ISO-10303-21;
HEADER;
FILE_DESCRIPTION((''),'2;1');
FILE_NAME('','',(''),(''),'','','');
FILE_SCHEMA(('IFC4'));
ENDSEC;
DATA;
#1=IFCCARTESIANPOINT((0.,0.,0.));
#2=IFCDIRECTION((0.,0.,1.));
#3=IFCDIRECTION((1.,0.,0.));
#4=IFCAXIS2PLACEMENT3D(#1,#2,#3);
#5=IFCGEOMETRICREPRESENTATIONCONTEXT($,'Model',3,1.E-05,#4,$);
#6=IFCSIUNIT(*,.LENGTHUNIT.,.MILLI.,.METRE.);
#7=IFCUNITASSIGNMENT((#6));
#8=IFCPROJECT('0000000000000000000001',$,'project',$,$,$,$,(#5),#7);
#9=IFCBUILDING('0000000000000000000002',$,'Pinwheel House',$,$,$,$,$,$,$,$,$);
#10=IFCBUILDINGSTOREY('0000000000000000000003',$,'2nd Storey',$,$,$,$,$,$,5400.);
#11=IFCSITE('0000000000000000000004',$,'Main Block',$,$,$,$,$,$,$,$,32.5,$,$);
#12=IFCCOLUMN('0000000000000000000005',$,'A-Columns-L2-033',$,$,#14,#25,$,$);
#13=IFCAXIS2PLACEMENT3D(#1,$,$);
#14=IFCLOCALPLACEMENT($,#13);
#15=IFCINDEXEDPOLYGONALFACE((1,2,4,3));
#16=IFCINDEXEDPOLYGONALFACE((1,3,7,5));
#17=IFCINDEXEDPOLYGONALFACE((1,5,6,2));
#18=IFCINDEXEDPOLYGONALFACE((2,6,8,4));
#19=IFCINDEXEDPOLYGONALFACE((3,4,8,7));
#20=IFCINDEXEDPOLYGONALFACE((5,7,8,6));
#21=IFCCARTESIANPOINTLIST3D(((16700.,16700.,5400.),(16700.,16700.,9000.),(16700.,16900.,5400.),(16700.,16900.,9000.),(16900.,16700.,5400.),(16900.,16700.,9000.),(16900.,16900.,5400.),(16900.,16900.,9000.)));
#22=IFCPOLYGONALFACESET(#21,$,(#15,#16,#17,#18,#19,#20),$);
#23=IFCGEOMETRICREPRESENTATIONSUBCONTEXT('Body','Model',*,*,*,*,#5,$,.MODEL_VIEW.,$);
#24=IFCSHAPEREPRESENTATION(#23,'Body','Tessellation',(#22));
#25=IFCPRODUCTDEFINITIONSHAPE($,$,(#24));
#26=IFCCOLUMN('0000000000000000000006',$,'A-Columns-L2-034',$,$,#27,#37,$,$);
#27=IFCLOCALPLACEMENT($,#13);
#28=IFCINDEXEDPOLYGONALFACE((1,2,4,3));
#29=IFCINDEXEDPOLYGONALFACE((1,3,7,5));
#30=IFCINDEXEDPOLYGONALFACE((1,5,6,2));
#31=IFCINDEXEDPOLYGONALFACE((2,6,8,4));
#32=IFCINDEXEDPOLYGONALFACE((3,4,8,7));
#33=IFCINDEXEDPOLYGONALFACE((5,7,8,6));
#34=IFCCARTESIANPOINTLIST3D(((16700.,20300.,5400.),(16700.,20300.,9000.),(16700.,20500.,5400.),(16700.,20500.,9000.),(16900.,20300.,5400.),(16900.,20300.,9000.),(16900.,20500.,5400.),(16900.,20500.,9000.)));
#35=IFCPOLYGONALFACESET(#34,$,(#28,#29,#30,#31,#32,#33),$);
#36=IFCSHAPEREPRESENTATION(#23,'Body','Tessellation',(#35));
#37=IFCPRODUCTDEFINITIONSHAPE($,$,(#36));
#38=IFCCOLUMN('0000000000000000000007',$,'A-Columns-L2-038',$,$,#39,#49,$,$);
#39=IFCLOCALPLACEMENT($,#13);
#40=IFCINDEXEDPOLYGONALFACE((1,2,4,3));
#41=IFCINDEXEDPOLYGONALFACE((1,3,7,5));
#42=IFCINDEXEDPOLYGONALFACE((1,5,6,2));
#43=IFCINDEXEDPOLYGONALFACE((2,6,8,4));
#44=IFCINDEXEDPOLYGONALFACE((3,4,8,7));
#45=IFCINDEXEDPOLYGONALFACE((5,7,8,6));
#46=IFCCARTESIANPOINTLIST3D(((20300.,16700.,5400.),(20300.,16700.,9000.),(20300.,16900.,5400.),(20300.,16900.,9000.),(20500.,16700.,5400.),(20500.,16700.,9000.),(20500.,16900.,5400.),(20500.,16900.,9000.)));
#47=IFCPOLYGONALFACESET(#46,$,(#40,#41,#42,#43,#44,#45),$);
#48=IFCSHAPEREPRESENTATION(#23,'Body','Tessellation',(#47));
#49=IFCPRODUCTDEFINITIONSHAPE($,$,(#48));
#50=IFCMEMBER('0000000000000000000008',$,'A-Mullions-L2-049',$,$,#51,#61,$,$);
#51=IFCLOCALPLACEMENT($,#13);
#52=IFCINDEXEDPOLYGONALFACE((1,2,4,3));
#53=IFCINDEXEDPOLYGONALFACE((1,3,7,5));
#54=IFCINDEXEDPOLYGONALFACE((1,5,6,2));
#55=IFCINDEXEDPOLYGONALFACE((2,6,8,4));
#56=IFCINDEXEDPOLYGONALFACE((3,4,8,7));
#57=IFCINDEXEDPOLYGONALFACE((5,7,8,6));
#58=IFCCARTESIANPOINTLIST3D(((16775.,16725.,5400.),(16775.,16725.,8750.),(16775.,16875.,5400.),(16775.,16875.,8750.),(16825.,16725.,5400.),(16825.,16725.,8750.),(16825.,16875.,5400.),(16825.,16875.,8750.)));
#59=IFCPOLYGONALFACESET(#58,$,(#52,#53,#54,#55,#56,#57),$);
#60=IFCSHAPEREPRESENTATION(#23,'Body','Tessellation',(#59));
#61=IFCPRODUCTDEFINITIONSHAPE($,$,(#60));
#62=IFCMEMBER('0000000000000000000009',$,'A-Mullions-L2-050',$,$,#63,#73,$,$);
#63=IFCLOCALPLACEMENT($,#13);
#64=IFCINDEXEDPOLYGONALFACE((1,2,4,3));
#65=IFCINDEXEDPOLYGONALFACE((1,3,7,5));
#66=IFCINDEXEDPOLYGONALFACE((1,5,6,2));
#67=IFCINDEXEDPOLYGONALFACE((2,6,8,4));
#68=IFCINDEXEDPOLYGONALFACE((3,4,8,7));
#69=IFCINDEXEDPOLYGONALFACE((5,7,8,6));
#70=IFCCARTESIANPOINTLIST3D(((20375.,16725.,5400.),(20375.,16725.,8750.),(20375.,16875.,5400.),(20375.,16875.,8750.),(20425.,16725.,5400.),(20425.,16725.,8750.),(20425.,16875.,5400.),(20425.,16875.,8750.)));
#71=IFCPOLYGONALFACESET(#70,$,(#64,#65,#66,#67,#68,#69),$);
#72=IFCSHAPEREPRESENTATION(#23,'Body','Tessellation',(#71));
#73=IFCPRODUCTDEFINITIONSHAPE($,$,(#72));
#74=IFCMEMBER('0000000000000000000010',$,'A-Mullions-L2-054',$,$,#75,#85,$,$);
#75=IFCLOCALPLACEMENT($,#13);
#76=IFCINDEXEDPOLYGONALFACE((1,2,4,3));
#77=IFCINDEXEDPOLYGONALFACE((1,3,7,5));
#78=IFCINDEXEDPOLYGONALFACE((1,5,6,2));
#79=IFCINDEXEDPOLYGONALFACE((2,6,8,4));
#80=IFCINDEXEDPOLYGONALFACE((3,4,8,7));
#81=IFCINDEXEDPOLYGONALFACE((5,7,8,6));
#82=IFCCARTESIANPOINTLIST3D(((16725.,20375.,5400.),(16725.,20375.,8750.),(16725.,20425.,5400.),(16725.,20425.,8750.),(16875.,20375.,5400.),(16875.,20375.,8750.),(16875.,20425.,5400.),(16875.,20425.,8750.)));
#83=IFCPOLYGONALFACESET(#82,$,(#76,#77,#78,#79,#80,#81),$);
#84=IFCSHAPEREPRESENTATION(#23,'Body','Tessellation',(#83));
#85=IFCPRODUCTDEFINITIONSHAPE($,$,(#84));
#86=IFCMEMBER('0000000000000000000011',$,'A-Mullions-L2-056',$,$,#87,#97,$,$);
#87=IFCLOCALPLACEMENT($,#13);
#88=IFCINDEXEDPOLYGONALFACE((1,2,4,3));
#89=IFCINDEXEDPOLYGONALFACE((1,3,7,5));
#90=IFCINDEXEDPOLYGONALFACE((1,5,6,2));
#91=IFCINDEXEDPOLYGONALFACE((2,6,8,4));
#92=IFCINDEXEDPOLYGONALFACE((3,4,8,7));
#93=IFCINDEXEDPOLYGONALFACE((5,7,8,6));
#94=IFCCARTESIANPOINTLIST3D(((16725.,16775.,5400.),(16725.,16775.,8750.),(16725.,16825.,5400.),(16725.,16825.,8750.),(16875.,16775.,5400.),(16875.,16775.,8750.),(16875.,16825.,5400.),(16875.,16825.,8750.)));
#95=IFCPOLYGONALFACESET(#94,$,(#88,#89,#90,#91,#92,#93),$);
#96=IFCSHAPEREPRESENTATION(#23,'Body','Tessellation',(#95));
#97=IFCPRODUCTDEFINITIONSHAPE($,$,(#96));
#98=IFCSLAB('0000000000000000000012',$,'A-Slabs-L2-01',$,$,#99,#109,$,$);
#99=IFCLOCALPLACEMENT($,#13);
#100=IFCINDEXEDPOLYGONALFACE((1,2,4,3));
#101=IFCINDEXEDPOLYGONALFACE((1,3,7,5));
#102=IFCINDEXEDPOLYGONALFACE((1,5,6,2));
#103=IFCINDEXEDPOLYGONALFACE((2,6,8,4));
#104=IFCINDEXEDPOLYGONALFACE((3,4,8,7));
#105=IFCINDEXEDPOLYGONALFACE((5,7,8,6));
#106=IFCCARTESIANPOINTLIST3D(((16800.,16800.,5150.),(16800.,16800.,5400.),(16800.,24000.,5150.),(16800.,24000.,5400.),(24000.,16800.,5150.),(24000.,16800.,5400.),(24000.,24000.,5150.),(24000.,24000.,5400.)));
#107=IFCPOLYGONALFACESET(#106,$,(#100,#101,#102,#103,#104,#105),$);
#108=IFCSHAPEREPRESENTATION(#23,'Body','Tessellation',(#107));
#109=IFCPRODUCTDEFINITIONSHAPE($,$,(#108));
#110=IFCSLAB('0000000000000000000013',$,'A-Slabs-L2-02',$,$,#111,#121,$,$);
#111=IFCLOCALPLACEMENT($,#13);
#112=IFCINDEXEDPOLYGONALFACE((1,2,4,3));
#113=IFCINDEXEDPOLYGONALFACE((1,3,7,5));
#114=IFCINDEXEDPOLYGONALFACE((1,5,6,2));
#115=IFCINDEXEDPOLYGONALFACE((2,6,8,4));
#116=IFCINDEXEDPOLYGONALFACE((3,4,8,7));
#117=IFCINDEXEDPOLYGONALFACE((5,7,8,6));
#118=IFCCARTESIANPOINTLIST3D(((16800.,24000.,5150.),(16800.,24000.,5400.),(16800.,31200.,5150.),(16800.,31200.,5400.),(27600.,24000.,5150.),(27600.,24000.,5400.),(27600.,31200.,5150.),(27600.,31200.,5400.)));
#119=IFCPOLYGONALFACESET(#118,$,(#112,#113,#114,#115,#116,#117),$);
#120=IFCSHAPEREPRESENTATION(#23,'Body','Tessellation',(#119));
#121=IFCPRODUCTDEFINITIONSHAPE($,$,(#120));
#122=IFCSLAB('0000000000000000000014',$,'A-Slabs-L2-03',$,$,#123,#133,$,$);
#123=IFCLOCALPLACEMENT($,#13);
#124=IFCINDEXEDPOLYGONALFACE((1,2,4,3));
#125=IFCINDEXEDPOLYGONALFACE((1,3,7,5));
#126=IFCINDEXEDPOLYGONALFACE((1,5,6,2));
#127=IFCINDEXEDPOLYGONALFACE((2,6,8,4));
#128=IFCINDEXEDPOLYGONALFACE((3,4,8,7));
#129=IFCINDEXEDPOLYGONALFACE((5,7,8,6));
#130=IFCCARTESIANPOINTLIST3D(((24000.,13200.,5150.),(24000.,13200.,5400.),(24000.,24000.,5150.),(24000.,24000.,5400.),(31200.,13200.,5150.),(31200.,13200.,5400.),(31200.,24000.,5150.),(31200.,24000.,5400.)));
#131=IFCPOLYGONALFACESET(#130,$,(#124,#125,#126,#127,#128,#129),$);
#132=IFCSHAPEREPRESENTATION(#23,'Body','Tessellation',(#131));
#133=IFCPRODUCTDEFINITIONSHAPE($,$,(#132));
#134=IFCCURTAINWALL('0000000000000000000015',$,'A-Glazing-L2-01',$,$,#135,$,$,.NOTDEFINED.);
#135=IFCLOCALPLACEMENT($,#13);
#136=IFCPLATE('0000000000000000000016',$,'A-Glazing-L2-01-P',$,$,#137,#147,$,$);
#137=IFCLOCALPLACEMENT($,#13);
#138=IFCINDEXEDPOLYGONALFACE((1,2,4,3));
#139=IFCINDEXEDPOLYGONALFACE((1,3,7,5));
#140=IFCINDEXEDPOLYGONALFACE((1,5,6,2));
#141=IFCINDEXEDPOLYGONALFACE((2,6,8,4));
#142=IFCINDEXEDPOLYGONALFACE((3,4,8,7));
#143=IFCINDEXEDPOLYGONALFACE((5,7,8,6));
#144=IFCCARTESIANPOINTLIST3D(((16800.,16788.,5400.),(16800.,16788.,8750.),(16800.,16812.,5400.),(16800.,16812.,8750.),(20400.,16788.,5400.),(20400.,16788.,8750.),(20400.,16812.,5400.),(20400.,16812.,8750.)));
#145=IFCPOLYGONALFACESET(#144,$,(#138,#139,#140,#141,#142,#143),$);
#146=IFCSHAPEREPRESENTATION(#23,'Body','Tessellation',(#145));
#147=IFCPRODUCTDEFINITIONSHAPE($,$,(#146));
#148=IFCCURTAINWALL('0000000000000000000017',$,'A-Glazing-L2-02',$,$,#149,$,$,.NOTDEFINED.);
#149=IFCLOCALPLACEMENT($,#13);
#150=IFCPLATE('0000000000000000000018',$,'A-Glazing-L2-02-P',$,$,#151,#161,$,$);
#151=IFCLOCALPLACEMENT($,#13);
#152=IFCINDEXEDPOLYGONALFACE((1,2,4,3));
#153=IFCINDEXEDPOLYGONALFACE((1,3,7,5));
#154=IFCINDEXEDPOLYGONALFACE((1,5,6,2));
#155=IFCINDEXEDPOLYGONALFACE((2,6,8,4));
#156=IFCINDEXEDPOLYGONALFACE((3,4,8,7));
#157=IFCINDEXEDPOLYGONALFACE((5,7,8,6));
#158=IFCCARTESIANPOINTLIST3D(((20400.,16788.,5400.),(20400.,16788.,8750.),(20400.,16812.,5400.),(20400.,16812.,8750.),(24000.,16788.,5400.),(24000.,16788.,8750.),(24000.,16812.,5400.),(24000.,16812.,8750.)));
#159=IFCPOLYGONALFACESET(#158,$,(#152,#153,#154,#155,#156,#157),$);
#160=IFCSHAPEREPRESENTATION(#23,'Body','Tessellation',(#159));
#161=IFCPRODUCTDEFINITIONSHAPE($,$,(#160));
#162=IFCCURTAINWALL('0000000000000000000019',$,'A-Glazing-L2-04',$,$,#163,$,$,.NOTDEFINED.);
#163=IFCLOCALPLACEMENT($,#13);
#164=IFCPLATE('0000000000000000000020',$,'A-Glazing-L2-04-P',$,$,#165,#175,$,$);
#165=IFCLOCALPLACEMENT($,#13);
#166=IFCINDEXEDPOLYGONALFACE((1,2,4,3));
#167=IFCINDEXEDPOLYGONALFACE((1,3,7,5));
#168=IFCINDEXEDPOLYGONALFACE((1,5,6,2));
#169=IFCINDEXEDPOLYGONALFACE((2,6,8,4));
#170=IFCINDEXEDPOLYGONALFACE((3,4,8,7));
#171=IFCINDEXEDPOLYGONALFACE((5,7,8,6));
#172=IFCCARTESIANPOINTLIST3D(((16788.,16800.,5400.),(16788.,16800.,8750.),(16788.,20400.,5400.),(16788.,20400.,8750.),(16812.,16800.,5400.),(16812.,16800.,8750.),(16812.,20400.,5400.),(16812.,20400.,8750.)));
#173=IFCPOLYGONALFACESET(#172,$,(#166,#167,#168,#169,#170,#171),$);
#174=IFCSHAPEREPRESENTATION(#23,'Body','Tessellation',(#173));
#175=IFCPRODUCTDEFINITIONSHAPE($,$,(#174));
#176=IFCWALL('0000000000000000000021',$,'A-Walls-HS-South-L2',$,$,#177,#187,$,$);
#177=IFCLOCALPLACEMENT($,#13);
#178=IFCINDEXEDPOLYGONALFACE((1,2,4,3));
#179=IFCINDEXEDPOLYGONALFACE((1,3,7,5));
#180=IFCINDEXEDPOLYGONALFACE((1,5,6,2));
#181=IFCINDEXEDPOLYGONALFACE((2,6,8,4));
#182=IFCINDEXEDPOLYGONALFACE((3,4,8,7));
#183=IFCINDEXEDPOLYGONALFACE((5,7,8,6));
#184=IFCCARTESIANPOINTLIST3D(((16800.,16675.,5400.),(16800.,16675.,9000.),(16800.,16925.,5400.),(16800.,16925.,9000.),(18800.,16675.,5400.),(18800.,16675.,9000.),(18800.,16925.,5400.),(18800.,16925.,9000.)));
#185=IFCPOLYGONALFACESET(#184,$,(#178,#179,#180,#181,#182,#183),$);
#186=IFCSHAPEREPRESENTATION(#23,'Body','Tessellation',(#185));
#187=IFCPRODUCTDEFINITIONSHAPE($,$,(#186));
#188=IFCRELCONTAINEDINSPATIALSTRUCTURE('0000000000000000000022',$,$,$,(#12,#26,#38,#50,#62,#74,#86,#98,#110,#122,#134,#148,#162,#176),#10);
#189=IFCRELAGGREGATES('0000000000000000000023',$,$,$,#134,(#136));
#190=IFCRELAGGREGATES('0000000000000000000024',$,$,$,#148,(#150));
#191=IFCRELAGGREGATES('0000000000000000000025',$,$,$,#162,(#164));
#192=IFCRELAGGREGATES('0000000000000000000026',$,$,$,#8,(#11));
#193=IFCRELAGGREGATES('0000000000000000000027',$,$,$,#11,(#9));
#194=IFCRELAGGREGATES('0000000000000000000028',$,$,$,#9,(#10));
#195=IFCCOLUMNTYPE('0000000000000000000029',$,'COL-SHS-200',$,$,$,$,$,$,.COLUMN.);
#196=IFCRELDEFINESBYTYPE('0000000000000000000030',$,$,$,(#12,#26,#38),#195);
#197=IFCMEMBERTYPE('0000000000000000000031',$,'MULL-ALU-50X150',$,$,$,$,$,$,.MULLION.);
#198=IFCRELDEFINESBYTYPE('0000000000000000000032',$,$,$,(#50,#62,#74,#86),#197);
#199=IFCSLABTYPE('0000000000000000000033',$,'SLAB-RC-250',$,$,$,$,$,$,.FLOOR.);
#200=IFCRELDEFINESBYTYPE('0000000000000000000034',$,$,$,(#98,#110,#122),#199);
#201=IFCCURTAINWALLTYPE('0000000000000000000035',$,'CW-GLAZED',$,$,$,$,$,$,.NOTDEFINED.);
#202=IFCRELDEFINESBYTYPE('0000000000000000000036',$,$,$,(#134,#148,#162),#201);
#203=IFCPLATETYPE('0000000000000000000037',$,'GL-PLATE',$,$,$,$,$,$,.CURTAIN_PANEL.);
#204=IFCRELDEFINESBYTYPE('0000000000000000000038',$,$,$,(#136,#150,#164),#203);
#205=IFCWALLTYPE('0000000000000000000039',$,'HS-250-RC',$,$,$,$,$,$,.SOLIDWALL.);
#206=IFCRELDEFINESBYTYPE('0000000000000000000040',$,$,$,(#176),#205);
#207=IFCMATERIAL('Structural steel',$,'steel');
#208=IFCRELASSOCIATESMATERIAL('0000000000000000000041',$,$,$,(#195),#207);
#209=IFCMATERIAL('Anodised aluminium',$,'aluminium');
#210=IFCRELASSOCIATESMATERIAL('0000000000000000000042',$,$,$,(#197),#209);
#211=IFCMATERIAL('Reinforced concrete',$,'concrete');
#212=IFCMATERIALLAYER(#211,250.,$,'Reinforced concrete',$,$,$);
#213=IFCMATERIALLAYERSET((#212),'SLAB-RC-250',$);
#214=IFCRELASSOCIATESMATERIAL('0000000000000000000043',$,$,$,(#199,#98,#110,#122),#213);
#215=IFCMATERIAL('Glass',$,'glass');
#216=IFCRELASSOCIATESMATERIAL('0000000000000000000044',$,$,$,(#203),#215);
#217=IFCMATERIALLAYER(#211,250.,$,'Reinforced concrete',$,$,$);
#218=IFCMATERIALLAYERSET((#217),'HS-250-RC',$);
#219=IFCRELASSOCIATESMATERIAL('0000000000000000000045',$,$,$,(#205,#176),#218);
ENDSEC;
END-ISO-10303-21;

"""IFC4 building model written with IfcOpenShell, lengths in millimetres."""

from ifc_helpers import new_model, si_unit, frame, origin_with_axes, place, context, subcontext, project, spatial, indexed_curve, outline, extrude, material, layer, layer_set, layer_usage, type_object, element, aggregate, save


model = new_model("IFC4")

# Units and contexts
model_context = context("Model", 3, precision=1e-05, world=origin_with_axes())
body_context = subcontext(model_context, "Body", "Model", "MODEL_VIEW")
ifc_project = project(units=[si_unit("LENGTHUNIT", "METRE", prefix="MILLI")], contexts=[model_context])

# Site, building, storey
site = spatial("IfcSite", under=ifc_project, Name="Main Block", RefElevation=32.5)
building = spatial("IfcBuilding", under=site, Name="Pinwheel House")
storey = spatial("IfcBuildingStorey", under=building, Name="2nd Storey", Elevation=5400.0)

# Columns
ifc_material_1 = material(Name="Structural steel", Category="steel")
column_type = type_object("IfcColumnType", Name="COL-SHS-200", PredefinedType="COLUMN", material=ifc_material_1)
for number, where, z_axis, x_axis, name in (
    (1, (16800.0, 16800.0, 5400.0), (0.0, 0.0, 1.0), (1.0, 0.0, 0.0), "A-Columns-L2-033"),
    (2, (16800.0, 20400.0, 5400.0), (0.0, 0.0, 1.0), (1.0, 0.0, 0.0), "A-Columns-L2-034"),
    (3, (20400.0, 16800.0, 5400.0), (0.0, 0.0, 1.0), (1.0, 0.0, 0.0), "A-Columns-L2-038"),
):
    element("IfcColumn", number, at=place(None, frame(where, z_axis=z_axis, x_axis=x_axis)), inside=storey, type_object=column_type, Name=name, context=body_context, shape_type="SweptSolid", body=[
        extrude(outline(indexed_curve([(-100.0, -100.0), (100.0, -100.0), (100.0, 100.0), (-100.0, 100.0)])), None, (0.0, 0.0, 1.0), 3600.0),
    ])

# Members
ifc_material_2 = material(Name="Anodised aluminium", Category="aluminium")
member_type = type_object("IfcMemberType", Name="MULL-ALU-50X150", PredefinedType="MULLION", material=ifc_material_2)
for number, where, z_axis, x_axis, name in (
    (4, (16800.0, 16800.0, 5400.0), (0.0, 0.0, 1.0), (1.0, 0.0, 0.0), "A-Mullions-L2-049"),
    (5, (20400.0, 16800.0, 5400.0), (0.0, 0.0, 1.0), (1.0, 0.0, 0.0), "A-Mullions-L2-050"),
    (6, (16800.0, 20400.0, 5400.0), (0.0, 0.0, 1.0), (0.0, -1.0, 0.0), "A-Mullions-L2-054"),
    (7, (16800.0, 16800.0, 5400.0), (0.0, 0.0, 1.0), (0.0, -1.0, 0.0), "A-Mullions-L2-056"),
):
    element("IfcMember", number, at=place(None, frame(where, z_axis=z_axis, x_axis=x_axis)), inside=storey, type_object=member_type, Name=name, context=body_context, shape_type="SweptSolid", body=[
        extrude(outline(indexed_curve([(-25.0, -75.0), (25.0, -75.0), (25.0, 75.0), (-25.0, 75.0)])), None, (0.0, 0.0, 1.0), 3350.0),
    ])

# Slabs
ifc_material_3 = material(Name="Reinforced concrete", Category="concrete")
ifc_layer_1 = layer(ifc_material_3, 250.0, Name="Reinforced concrete")
ifc_layer_set_1 = layer_set([ifc_layer_1], Name="SLAB-RC-250")
ifc_layer_usage_1 = layer_usage(ifc_layer_set_1, "AXIS3", "POSITIVE", 0.0)
slab_type = type_object("IfcSlabType", Name="SLAB-RC-250", PredefinedType="FLOOR", material=ifc_layer_set_1)
slab_1_placement = place(None, frame((0.0, 0.0, 5150.0), z_axis=(0.0, 0.0, 1.0), x_axis=(1.0, 0.0, 0.0)))
element("IfcSlab", 8, at=slab_1_placement, inside=storey, type_object=slab_type, material=ifc_layer_usage_1, Name="A-Slabs-L2-01", context=body_context, shape_type="SweptSolid", body=[
    extrude(outline(indexed_curve([(16800.0, 16800.0), (24000.0, 16800.0), (24000.0, 24000.0), (16800.0, 24000.0)])), None, (0.0, 0.0, 1.0), 250.0),
])
ifc_layer_usage_2 = layer_usage(ifc_layer_set_1, "AXIS3", "POSITIVE", 0.0)
slab_2_placement = place(None, frame((0.0, 0.0, 5150.0), z_axis=(0.0, 0.0, 1.0), x_axis=(1.0, 0.0, 0.0)))
element("IfcSlab", 9, at=slab_2_placement, inside=storey, type_object=slab_type, material=ifc_layer_usage_2, Name="A-Slabs-L2-02", context=body_context, shape_type="SweptSolid", body=[
    extrude(outline(indexed_curve([(16800.0, 24000.0), (27600.0, 24000.0), (27600.0, 31200.0), (16800.0, 31200.0)])), None, (0.0, 0.0, 1.0), 250.0),
])
ifc_layer_usage_3 = layer_usage(ifc_layer_set_1, "AXIS3", "POSITIVE", 0.0)
slab_3_placement = place(None, frame((0.0, 0.0, 5150.0), z_axis=(0.0, 0.0, 1.0), x_axis=(1.0, 0.0, 0.0)))
element("IfcSlab", 10, at=slab_3_placement, inside=storey, type_object=slab_type, material=ifc_layer_usage_3, Name="A-Slabs-L2-03", context=body_context, shape_type="SweptSolid", body=[
    extrude(outline(indexed_curve([(24000.0, 13200.0), (31200.0, 13200.0), (31200.0, 24000.0), (24000.0, 24000.0)])), None, (0.0, 0.0, 1.0), 250.0),
])

# Curtain walls, plates
curtain_wall_type = type_object("IfcCurtainWallType", Name="CW-GLAZED", PredefinedType="NOTDEFINED")
curtain_wall_1 = element("IfcCurtainWall", 11, inside=storey, type_object=curtain_wall_type, Name="A-Glazing-L2-01", PredefinedType="NOTDEFINED")
ifc_material_4 = material(Name="Glass", Category="glass")
plate_type = type_object("IfcPlateType", Name="GL-PLATE", PredefinedType="CURTAIN_PANEL", material=ifc_material_4)
plate_1_placement = place(None, frame((18600.0, 16800.0, 5400.0), z_axis=(0.0, 0.0, 1.0), x_axis=(1.0, 0.0, 0.0)))
plate_1 = element("IfcPlate", 12, at=plate_1_placement, type_object=plate_type, Name="A-Glazing-L2-01-P", context=body_context, shape_type="SweptSolid", body=[
    extrude(outline(indexed_curve([(-1800.0, -12.0), (1800.0, -12.0), (1800.0, 12.0), (-1800.0, 12.0)])), None, (0.0, 0.0, 1.0), 3350.0),
])
aggregate(curtain_wall_1, [plate_1])
curtain_wall_2 = element("IfcCurtainWall", 13, inside=storey, type_object=curtain_wall_type, Name="A-Glazing-L2-02", PredefinedType="NOTDEFINED")
plate_2_placement = place(None, frame((22200.0, 16800.0, 5400.0), z_axis=(0.0, 0.0, 1.0), x_axis=(1.0, 0.0, 0.0)))
plate_2 = element("IfcPlate", 14, at=plate_2_placement, type_object=plate_type, Name="A-Glazing-L2-02-P", context=body_context, shape_type="SweptSolid", body=[
    extrude(outline(indexed_curve([(-1800.0, -12.0), (1800.0, -12.0), (1800.0, 12.0), (-1800.0, 12.0)])), None, (0.0, 0.0, 1.0), 3350.0),
])
aggregate(curtain_wall_2, [plate_2])
curtain_wall_3 = element("IfcCurtainWall", 15, inside=storey, type_object=curtain_wall_type, Name="A-Glazing-L2-04", PredefinedType="NOTDEFINED")
plate_3_placement = place(None, frame((16800.0, 18600.0, 5400.0), z_axis=(0.0, 0.0, 1.0), x_axis=(0.0, -1.0, 0.0)))
plate_3 = element("IfcPlate", 16, at=plate_3_placement, type_object=plate_type, Name="A-Glazing-L2-04-P", context=body_context, shape_type="SweptSolid", body=[
    extrude(outline(indexed_curve([(-1800.0, -12.0), (1800.0, -12.0), (1800.0, 12.0), (-1800.0, 12.0)])), None, (0.0, 0.0, 1.0), 3350.0),
])
aggregate(curtain_wall_3, [plate_3])

# Wall
ifc_layer_2 = layer(ifc_material_3, 250.0, Name="Reinforced concrete")
ifc_layer_set_2 = layer_set([ifc_layer_2], Name="HS-250-RC")
ifc_layer_usage_4 = layer_usage(ifc_layer_set_2, "AXIS2", "POSITIVE", 0.0)
wall_type_1 = type_object("IfcWallType", Name="HS-250-RC", PredefinedType="SOLIDWALL", material=ifc_layer_set_2)
wall_1_placement = place(None, frame((16800.0, 16675.0, 5400.0), z_axis=(0.0, 0.0, 1.0), x_axis=(1.0, 0.0, 0.0)))
element("IfcWall", 17, at=wall_1_placement, inside=storey, type_object=wall_type_1, material=ifc_layer_usage_4, Name="A-Walls-HS-South-L2", context=body_context, shape_type="SweptSolid", body=[
    extrude(outline(indexed_curve([(0.0, 0.0), (0.0, 250.0), (2000.0, 250.0), (2000.0, 0.0), (0.0, 0.0)], self_intersect=False)), origin_with_axes(), (0.0, 0.0, 1.0), 3600.0),
])

save(model, "model.ifc")
